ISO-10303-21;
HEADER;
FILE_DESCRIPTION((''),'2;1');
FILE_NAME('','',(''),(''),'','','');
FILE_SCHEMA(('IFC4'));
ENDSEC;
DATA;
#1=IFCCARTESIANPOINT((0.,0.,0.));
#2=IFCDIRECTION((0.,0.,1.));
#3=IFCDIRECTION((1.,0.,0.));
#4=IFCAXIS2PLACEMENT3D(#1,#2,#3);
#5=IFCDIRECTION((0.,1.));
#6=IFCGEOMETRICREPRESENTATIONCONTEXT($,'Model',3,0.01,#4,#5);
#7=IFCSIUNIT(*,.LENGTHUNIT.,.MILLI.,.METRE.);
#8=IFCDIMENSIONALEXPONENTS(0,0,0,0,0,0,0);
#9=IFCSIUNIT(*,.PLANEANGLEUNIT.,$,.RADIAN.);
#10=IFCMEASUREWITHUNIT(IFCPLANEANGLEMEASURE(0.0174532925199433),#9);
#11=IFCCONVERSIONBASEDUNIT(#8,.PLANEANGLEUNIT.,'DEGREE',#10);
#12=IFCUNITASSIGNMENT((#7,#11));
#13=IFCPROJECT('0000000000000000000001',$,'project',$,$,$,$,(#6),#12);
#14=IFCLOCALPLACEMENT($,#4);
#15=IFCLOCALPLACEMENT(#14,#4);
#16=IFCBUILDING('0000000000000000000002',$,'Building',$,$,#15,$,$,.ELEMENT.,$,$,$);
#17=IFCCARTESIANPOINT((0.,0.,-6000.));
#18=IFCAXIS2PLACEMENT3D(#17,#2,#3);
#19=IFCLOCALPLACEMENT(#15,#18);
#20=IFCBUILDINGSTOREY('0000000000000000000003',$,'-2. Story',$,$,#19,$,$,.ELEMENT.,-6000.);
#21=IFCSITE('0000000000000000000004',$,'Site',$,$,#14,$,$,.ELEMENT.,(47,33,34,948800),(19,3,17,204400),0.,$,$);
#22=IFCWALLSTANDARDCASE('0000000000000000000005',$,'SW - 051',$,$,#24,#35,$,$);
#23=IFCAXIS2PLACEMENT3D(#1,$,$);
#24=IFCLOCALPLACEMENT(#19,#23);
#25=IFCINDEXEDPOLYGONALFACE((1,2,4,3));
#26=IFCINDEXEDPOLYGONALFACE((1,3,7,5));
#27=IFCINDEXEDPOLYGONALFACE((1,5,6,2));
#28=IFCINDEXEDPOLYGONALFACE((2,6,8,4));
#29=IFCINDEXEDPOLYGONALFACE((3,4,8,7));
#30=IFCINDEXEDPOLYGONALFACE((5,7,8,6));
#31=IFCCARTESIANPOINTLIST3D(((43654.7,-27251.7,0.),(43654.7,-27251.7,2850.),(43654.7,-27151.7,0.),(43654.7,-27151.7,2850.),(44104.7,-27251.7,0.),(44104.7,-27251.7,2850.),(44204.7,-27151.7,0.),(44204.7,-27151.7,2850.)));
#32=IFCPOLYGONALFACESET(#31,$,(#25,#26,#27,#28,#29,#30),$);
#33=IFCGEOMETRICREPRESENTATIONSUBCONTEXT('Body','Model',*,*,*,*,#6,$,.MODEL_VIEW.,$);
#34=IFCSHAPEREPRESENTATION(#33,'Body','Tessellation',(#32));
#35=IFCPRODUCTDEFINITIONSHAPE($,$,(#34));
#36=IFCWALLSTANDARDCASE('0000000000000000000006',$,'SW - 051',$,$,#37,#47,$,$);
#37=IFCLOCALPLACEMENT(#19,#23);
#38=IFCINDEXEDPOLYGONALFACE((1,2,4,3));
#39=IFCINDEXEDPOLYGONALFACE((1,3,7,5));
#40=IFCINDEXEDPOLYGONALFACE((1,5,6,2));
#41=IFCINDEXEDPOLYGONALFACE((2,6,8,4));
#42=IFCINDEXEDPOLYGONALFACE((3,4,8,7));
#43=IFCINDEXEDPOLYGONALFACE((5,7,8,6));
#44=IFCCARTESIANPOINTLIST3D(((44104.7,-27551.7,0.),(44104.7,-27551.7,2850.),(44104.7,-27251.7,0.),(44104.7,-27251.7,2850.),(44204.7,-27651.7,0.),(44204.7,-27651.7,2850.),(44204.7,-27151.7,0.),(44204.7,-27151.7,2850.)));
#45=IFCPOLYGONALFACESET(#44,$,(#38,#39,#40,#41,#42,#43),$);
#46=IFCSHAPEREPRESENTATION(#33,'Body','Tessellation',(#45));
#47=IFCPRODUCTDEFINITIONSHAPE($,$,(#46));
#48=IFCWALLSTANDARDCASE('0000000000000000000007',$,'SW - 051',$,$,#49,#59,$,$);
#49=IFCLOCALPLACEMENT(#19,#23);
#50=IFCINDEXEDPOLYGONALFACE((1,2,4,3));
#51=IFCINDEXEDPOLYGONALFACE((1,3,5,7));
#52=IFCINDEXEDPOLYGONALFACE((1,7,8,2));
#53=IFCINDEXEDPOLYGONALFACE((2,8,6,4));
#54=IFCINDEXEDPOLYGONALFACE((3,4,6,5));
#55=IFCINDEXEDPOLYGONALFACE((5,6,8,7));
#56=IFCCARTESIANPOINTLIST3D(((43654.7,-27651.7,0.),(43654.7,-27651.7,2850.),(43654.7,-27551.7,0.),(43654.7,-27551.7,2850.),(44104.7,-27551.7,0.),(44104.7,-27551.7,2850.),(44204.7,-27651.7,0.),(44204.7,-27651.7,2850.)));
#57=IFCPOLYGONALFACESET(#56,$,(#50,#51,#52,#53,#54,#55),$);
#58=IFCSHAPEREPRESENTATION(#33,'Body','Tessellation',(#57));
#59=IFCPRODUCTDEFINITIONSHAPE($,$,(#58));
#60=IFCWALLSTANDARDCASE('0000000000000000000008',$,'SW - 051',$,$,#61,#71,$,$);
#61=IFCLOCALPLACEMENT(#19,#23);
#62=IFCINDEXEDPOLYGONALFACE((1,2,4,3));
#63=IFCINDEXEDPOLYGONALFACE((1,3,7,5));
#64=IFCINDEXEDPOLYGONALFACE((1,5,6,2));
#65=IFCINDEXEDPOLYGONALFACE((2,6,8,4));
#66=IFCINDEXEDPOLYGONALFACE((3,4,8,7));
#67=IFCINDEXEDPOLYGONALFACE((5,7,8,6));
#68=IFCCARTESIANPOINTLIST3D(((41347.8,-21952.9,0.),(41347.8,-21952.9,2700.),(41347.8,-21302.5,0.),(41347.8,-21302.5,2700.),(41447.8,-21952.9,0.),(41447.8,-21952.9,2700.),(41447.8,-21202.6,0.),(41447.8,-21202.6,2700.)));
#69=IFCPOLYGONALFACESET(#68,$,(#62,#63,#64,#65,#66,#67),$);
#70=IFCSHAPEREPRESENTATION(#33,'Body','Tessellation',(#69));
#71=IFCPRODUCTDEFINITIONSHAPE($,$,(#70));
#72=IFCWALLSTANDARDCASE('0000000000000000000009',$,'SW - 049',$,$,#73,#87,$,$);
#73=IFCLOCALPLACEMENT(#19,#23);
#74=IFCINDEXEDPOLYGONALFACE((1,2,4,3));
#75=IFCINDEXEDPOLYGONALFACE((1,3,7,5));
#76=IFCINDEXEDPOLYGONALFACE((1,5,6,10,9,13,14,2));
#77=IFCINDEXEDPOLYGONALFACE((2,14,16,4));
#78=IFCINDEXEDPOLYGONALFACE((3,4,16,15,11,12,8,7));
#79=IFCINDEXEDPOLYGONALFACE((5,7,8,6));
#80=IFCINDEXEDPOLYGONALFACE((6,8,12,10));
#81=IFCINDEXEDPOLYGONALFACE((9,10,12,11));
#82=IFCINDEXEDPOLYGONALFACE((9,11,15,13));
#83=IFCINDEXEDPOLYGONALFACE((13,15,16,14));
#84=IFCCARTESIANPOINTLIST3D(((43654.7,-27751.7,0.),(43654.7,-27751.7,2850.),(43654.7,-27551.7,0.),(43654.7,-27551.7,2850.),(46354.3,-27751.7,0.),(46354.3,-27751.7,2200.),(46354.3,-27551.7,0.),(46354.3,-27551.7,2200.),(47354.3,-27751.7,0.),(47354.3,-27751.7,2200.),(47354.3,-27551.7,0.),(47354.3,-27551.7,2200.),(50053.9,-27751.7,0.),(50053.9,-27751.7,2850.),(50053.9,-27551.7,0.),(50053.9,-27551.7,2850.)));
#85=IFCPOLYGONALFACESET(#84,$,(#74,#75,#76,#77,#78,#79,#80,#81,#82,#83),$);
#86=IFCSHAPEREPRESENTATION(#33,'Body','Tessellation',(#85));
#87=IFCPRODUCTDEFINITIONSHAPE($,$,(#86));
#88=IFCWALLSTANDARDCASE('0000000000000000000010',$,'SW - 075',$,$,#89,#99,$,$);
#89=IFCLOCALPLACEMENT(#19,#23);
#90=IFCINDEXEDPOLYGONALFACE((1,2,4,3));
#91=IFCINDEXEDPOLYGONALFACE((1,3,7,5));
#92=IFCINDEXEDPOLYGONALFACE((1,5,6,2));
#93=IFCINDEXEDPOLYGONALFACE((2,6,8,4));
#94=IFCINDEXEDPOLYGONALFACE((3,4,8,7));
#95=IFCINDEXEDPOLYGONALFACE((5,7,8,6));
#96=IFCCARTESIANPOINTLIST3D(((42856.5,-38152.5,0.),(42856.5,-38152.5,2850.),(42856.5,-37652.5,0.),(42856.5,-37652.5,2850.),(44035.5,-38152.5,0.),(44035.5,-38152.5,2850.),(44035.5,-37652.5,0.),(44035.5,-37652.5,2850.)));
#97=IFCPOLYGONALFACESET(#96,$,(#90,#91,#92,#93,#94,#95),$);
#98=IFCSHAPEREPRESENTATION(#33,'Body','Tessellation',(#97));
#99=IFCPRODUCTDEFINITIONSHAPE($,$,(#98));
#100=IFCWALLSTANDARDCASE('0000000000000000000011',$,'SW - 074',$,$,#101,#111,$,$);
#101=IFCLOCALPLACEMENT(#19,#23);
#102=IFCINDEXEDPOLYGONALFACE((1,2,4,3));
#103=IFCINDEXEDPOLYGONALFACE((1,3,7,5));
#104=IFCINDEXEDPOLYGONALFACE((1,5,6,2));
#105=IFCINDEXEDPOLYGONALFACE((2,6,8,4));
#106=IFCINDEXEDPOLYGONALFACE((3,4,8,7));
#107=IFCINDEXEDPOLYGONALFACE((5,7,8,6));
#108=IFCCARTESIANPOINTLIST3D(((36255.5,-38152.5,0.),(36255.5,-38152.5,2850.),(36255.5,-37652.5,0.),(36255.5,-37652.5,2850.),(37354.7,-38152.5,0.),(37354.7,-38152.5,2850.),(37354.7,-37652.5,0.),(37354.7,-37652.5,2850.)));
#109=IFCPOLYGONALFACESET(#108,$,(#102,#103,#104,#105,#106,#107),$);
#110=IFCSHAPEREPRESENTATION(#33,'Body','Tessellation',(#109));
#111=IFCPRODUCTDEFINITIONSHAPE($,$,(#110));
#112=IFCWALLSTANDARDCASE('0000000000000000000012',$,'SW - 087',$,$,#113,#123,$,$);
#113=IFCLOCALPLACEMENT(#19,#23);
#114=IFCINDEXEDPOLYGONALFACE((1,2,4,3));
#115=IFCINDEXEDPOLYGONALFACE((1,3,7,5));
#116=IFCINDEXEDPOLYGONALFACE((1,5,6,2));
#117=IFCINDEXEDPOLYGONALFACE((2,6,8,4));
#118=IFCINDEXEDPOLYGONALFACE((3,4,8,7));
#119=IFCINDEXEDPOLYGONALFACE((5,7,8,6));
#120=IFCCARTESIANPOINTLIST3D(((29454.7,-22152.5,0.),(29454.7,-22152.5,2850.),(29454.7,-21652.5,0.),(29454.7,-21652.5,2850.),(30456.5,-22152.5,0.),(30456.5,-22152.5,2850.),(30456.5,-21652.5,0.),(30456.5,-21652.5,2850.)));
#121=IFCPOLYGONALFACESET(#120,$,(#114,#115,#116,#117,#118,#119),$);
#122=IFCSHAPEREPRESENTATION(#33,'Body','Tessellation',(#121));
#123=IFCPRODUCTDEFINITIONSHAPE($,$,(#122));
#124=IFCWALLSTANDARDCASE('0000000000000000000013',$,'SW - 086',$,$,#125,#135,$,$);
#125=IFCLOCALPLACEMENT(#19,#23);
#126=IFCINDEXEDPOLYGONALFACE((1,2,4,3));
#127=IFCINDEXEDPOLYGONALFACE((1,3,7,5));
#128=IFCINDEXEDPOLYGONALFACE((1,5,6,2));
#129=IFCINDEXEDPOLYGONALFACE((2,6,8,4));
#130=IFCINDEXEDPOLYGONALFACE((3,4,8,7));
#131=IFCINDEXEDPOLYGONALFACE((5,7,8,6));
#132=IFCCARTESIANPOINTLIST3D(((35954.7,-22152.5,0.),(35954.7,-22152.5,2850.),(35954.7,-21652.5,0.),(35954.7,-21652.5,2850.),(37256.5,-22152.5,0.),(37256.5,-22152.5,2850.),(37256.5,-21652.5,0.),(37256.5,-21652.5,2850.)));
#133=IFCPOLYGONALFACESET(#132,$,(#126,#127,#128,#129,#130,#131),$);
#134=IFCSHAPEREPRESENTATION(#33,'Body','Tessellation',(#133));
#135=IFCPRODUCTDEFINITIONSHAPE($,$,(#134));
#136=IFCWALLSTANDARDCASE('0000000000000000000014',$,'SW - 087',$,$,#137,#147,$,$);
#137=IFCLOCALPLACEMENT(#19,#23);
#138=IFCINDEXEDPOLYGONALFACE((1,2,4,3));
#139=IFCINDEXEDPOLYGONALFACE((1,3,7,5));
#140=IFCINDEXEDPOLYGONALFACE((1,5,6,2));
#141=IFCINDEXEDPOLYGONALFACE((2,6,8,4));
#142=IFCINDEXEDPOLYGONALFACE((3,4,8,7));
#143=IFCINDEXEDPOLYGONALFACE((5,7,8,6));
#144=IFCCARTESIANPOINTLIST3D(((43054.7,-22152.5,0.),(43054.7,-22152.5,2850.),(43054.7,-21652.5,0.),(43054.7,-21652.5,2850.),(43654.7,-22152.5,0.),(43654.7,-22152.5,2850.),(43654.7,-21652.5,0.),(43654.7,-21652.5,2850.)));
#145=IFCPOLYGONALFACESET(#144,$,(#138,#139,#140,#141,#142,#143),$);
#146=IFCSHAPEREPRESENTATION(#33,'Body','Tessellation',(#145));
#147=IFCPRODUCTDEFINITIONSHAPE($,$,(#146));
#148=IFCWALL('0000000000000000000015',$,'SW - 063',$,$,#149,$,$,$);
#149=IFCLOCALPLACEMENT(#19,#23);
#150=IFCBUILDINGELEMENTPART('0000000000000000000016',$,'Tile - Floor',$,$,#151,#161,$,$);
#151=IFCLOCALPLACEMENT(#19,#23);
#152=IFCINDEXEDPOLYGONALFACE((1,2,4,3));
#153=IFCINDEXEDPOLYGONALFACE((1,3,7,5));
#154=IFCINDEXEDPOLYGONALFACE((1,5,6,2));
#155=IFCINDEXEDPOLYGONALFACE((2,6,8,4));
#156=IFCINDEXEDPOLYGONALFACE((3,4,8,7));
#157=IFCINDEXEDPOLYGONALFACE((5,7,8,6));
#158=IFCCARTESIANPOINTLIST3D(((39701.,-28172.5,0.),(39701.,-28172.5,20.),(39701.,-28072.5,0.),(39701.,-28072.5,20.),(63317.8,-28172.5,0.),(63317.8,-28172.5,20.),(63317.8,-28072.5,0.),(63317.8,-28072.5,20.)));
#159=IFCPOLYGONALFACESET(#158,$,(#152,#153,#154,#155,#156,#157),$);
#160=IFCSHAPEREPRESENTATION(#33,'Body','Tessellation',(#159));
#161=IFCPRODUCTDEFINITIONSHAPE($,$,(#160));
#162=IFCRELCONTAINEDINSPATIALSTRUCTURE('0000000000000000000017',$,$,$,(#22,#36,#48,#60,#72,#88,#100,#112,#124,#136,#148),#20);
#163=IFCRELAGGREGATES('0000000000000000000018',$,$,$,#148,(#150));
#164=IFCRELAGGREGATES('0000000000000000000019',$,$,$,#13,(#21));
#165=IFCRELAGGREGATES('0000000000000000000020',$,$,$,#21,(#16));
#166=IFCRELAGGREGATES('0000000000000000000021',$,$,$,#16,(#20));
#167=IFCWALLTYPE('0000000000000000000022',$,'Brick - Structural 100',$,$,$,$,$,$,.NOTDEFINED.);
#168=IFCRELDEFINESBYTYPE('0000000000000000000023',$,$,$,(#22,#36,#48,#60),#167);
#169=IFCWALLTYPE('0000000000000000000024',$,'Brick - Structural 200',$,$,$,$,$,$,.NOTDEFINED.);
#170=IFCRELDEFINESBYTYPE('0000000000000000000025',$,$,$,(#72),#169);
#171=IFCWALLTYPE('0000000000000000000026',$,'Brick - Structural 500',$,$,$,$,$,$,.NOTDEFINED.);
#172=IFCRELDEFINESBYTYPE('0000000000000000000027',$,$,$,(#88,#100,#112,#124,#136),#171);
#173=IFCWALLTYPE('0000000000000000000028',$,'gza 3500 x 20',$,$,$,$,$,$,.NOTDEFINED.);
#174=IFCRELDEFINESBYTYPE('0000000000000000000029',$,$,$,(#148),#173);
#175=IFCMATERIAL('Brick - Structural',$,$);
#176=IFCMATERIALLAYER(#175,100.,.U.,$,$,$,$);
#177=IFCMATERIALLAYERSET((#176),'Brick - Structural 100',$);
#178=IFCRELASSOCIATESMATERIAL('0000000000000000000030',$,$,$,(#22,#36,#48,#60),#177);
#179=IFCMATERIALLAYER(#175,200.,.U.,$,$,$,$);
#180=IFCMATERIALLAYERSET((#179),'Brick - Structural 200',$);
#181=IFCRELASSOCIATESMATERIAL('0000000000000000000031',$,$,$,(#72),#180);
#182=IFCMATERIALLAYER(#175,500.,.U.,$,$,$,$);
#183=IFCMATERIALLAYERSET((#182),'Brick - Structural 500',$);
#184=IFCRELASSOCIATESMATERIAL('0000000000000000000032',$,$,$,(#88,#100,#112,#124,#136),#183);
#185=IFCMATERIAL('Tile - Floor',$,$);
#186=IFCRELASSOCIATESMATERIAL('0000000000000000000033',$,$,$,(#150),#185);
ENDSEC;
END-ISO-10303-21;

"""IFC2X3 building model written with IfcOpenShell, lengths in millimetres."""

from ifc_helpers import new_model, entity, si_unit, converted_unit, direction, frame, origin_with_axes, origin_2d_with_axis, place, context, subcontext, project, spatial, polyline, rectangle, outline, extrude, material, layer, layer_set, layer_usage, type_object, element, aggregate, save


model = new_model("IFC2X3")

# Units and contexts
model_context = context("Model", 3, precision=0.01, world=origin_with_axes(), true_north=direction((0.0, 1.0)))
body_context = subcontext(model_context, "Body", "Model", "MODEL_VIEW")
ifc_project = project(units=[si_unit("LENGTHUNIT", "METRE", prefix="MILLI"), converted_unit("PLANEANGLEUNIT", "DEGREE", entity("IfcPlaneAngleMeasure", 0.0174532925199433), si_unit("PLANEANGLEUNIT", "RADIAN"), dimensions=[0, 0, 0, 0, 0, 0, 0])], contexts=[model_context])

# Site, building, storey
site_placement = place(None, origin_with_axes())
site = spatial("IfcSite", under=ifc_project, at=site_placement, Name="Site", CompositionType="ELEMENT", RefLatitude=(47, 33, 34, 948800), RefLongitude=(19, 3, 17, 204400), RefElevation=0.0)
building_placement = place(site_placement, origin_with_axes())
building = spatial("IfcBuilding", under=site, at=building_placement, Name="Building", CompositionType="ELEMENT")
storey_placement = place(building_placement, frame((0.0, 0.0, -6000.0), z_axis=(0.0, 0.0, 1.0), x_axis=(1.0, 0.0, 0.0)))
storey = spatial("IfcBuildingStorey", under=building, at=storey_placement, Name="-2. Story", CompositionType="ELEMENT", Elevation=-6000.0)

# Walls
ifc_material_1 = material(Name="Brick - Structural")
ifc_layer_1 = layer(ifc_material_1, 100.0, ventilated="UNKNOWN")
ifc_layer_set_1 = layer_set([ifc_layer_1], Name="Brick - Structural 100")
wall_type_1 = type_object("IfcWallType", Name="Brick - Structural 100", PredefinedType="NOTDEFINED")
ifc_layer_usage_1 = layer_usage(ifc_layer_set_1, "AXIS2", "NEGATIVE", 0.0)
wall_1_placement = place(storey_placement, frame((44104.7, -27251.7, 0.0), z_axis=(0.0, 0.0, 1.0), x_axis=(-1.0, 0.0, 0.0)))
element("IfcWallStandardCase", 1, at=wall_1_placement, inside=storey, type_object=wall_type_1, material=ifc_layer_usage_1, Name="SW - 051", context=body_context, shape_type="SweptSolid", body=[
    extrude(outline(polyline([(-100.0, -100.0), (450.0, -100.0), (450.0, 0.0), (0.0, 0.0), (-100.0, -100.0)])), origin_with_axes(), (0.0, 0.0, 1.0), 2850.0),
])
ifc_layer_usage_2 = layer_usage(ifc_layer_set_1, "AXIS2", "NEGATIVE", 0.0)
wall_2_placement = place(storey_placement, frame((44104.7, -27651.7, 0.0), z_axis=(0.0, 0.0, 1.0), x_axis=(0.0, 1.0, 0.0)))
element("IfcWallStandardCase", 2, at=wall_2_placement, inside=storey, type_object=wall_type_1, material=ifc_layer_usage_2, Name="SW - 051", context=body_context, shape_type="SweptSolid", body=[
    extrude(outline(polyline([(0.0, -100.0), (500.0, -100.0), (400.0, 0.0), (100.0, 0.0), (0.0, -100.0)])), origin_with_axes(), (0.0, 0.0, 1.0), 2850.0),
])
ifc_layer_usage_3 = layer_usage(ifc_layer_set_1, "AXIS2", "NEGATIVE", 0.0)
wall_3_placement = place(storey_placement, frame((44104.7, -27651.7, 0.0), z_axis=(0.0, 0.0, 1.0), x_axis=(-1.0, 0.0, 0.0)))
element("IfcWallStandardCase", 3, at=wall_3_placement, inside=storey, type_object=wall_type_1, material=ifc_layer_usage_3, Name="SW - 051", context=body_context, shape_type="SweptSolid", body=[
    extrude(outline(polyline([(0.0, -100.0), (450.0, -100.0), (450.0, 0.0), (-100.0, 0.0), (0.0, -100.0)])), origin_with_axes(), (0.0, 0.0, 1.0), 2850.0),
])
ifc_layer_usage_4 = layer_usage(ifc_layer_set_1, "AXIS2", "NEGATIVE", 0.0)
wall_4_placement = place(storey_placement, frame((41347.8, -21952.9, 0.0), z_axis=(0.0, 0.0, 1.0), x_axis=(0.0, 1.0, 0.0)))
element("IfcWallStandardCase", 4, at=wall_4_placement, inside=storey, type_object=wall_type_1, material=ifc_layer_usage_4, Name="SW - 051", context=body_context, shape_type="SweptSolid", body=[
    extrude(outline(polyline([(0.0, -100.0), (750.4, -100.0), (650.4, 0.0), (0.0, 0.0), (0.0, -100.0)])), origin_with_axes(), (0.0, 0.0, 1.0), 2700.0),
])

# Wall, opening
ifc_layer_2 = layer(ifc_material_1, 200.0, ventilated="UNKNOWN")
ifc_layer_set_2 = layer_set([ifc_layer_2], Name="Brick - Structural 200")
ifc_layer_usage_5 = layer_usage(ifc_layer_set_2, "AXIS2", "POSITIVE", 0.0)
wall_type_2 = type_object("IfcWallType", Name="Brick - Structural 200", PredefinedType="NOTDEFINED")
wall_5_placement = place(storey_placement, frame((43654.7, -27751.7, 0.0), z_axis=(0.0, 0.0, 1.0), x_axis=(1.0, 0.0, 0.0)))
wall_5 = element("IfcWallStandardCase", 5, at=wall_5_placement, inside=storey, type_object=wall_type_2, material=ifc_layer_usage_5, Name="SW - 049", context=body_context, shape_type="SweptSolid", body=[
    extrude(outline(polyline([(0.0, 0.0), (6399.2, 0.0), (6399.2, 200.0), (0.0, 200.0), (0.0, 0.0)])), origin_with_axes(), (0.0, 0.0, 1.0), 2850.0),
])
opening_placement = place(wall_5_placement, frame((3199.6, 0.0, 0.0), z_axis=(0.0, 0.0, 1.0), x_axis=(1.0, 0.0, 0.0)))
element("IfcOpeningElement", 6, at=opening_placement, cuts=wall_5, context=body_context, shape_type="SweptSolid", body=[
    extrude(rectangle(XDim=1000.0, YDim=2200.0, at=origin_2d_with_axis()), frame((0.0, 200.0, 1100.0), z_axis=(0.0, -1.0, 0.0), x_axis=(1.0, 0.0, 0.0)), (0.0, 0.0, -1.0), 200.0),
    extrude(rectangle(XDim=1000.0, YDim=2200.0, at=origin_2d_with_axis()), frame((0.0, 200.0, 1100.0), z_axis=(0.0, 1.0, 0.0), x_axis=(1.0, 0.0, 0.0)), (0.0, 0.0, -1.0), 200.0),
])

# Walls
ifc_layer_3 = layer(ifc_material_1, 500.0, ventilated="UNKNOWN")
ifc_layer_set_3 = layer_set([ifc_layer_3], Name="Brick - Structural 500")
ifc_layer_usage_6 = layer_usage(ifc_layer_set_3, "AXIS2", "POSITIVE", 0.0)
wall_type_3 = type_object("IfcWallType", Name="Brick - Structural 500", PredefinedType="NOTDEFINED")
wall_6_placement = place(storey_placement, frame((42856.5, -38152.5, 0.0), z_axis=(0.0, 0.0, 1.0), x_axis=(1.0, 0.0, 0.0)))
element("IfcWallStandardCase", 7, at=wall_6_placement, inside=storey, type_object=wall_type_3, material=ifc_layer_usage_6, Name="SW - 075", context=body_context, shape_type="SweptSolid", body=[
    extrude(outline(polyline([(0.0, 0.0), (1179.0, 0.0), (1179.0, 500.0), (0.0, 500.0), (0.0, 0.0)])), origin_with_axes(), (0.0, 0.0, 1.0), 2850.0),
])
ifc_layer_usage_7 = layer_usage(ifc_layer_set_3, "AXIS2", "POSITIVE", 0.0)
wall_7_placement = place(storey_placement, frame((36255.5, -38152.5, 0.0), z_axis=(0.0, 0.0, 1.0), x_axis=(1.0, 0.0, 0.0)))
element("IfcWallStandardCase", 8, at=wall_7_placement, inside=storey, type_object=wall_type_3, material=ifc_layer_usage_7, Name="SW - 074", context=body_context, shape_type="SweptSolid", body=[
    extrude(outline(polyline([(0.0, 0.0), (1099.2, 0.0), (1099.2, 500.0), (0.0, 500.0), (0.0, 0.0)])), origin_with_axes(), (0.0, 0.0, 1.0), 2850.0),
])
ifc_layer_usage_8 = layer_usage(ifc_layer_set_3, "AXIS2", "POSITIVE", 0.0)
wall_8_placement = place(storey_placement, frame((30456.5, -21652.5, 0.0), z_axis=(0.0, 0.0, 1.0), x_axis=(-1.0, 0.0, 0.0)))
element("IfcWallStandardCase", 9, at=wall_8_placement, inside=storey, type_object=wall_type_3, material=ifc_layer_usage_8, Name="SW - 087", context=body_context, shape_type="SweptSolid", body=[
    extrude(outline(polyline([(0.0, 0.0), (1001.8, 0.0), (1001.8, 500.0), (0.0, 500.0), (0.0, 0.0)])), origin_with_axes(), (0.0, 0.0, 1.0), 2850.0),
])
ifc_layer_usage_9 = layer_usage(ifc_layer_set_3, "AXIS2", "POSITIVE", 0.0)
wall_9_placement = place(storey_placement, frame((37256.5, -21652.5, 0.0), z_axis=(0.0, 0.0, 1.0), x_axis=(-1.0, 0.0, 0.0)))
element("IfcWallStandardCase", 10, at=wall_9_placement, inside=storey, type_object=wall_type_3, material=ifc_layer_usage_9, Name="SW - 086", context=body_context, shape_type="SweptSolid", body=[
    extrude(outline(polyline([(0.0, 0.0), (1301.8, 0.0), (1301.8, 500.0), (0.0, 500.0), (0.0, 0.0)])), origin_with_axes(), (0.0, 0.0, 1.0), 2850.0),
])
ifc_layer_usage_10 = layer_usage(ifc_layer_set_3, "AXIS2", "NEGATIVE", 0.0)
wall_10_placement = place(storey_placement, frame((43054.7, -21652.5, 0.0), z_axis=(0.0, 0.0, 1.0), x_axis=(1.0, 0.0, 0.0)))
element("IfcWallStandardCase", 11, at=wall_10_placement, inside=storey, type_object=wall_type_3, material=ifc_layer_usage_10, Name="SW - 087", context=body_context, shape_type="SweptSolid", body=[
    extrude(outline(polyline([(0.0, -500.0), (600.0, -500.0), (600.0, 0.0), (0.0, 0.0), (0.0, -500.0)])), origin_with_axes(), (0.0, 0.0, 1.0), 2850.0),
])

# Wall, building element part
wall_type_4 = type_object("IfcWallType", Name="gza 3500 x 20", PredefinedType="NOTDEFINED")
wall_11_placement = place(storey_placement, frame((39701.0, -28072.5, 0.0), z_axis=(0.0, 0.0, 1.0), x_axis=(1.0, 0.0, 0.0)))
wall_11 = element("IfcWall", 12, at=wall_11_placement, inside=storey, type_object=wall_type_4, Name="SW - 063")
ifc_material_2 = material(Name="Tile - Floor")
building_element_part_1_placement = place(wall_11_placement, origin_with_axes())
building_element_part_1 = element("IfcBuildingElementPart", 13, at=building_element_part_1_placement, material=ifc_material_2, Name="Tile - Floor", context=body_context, shape_type="SweptSolid", body=[
    extrude(outline(polyline([(100.0, 0.0), (100.0, 20.0), (0.0, 20.0), (0.0, 0.0), (100.0, 0.0)])), frame((0.0, 0.0, 0.0), z_axis=(-1.0, 0.0, 0.0), x_axis=(0.0, -1.0, 0.0)), (0.0, 0.0, -1.0), 23616.8),
])
aggregate(wall_11, [building_element_part_1])

save(model, "model.ifc")
